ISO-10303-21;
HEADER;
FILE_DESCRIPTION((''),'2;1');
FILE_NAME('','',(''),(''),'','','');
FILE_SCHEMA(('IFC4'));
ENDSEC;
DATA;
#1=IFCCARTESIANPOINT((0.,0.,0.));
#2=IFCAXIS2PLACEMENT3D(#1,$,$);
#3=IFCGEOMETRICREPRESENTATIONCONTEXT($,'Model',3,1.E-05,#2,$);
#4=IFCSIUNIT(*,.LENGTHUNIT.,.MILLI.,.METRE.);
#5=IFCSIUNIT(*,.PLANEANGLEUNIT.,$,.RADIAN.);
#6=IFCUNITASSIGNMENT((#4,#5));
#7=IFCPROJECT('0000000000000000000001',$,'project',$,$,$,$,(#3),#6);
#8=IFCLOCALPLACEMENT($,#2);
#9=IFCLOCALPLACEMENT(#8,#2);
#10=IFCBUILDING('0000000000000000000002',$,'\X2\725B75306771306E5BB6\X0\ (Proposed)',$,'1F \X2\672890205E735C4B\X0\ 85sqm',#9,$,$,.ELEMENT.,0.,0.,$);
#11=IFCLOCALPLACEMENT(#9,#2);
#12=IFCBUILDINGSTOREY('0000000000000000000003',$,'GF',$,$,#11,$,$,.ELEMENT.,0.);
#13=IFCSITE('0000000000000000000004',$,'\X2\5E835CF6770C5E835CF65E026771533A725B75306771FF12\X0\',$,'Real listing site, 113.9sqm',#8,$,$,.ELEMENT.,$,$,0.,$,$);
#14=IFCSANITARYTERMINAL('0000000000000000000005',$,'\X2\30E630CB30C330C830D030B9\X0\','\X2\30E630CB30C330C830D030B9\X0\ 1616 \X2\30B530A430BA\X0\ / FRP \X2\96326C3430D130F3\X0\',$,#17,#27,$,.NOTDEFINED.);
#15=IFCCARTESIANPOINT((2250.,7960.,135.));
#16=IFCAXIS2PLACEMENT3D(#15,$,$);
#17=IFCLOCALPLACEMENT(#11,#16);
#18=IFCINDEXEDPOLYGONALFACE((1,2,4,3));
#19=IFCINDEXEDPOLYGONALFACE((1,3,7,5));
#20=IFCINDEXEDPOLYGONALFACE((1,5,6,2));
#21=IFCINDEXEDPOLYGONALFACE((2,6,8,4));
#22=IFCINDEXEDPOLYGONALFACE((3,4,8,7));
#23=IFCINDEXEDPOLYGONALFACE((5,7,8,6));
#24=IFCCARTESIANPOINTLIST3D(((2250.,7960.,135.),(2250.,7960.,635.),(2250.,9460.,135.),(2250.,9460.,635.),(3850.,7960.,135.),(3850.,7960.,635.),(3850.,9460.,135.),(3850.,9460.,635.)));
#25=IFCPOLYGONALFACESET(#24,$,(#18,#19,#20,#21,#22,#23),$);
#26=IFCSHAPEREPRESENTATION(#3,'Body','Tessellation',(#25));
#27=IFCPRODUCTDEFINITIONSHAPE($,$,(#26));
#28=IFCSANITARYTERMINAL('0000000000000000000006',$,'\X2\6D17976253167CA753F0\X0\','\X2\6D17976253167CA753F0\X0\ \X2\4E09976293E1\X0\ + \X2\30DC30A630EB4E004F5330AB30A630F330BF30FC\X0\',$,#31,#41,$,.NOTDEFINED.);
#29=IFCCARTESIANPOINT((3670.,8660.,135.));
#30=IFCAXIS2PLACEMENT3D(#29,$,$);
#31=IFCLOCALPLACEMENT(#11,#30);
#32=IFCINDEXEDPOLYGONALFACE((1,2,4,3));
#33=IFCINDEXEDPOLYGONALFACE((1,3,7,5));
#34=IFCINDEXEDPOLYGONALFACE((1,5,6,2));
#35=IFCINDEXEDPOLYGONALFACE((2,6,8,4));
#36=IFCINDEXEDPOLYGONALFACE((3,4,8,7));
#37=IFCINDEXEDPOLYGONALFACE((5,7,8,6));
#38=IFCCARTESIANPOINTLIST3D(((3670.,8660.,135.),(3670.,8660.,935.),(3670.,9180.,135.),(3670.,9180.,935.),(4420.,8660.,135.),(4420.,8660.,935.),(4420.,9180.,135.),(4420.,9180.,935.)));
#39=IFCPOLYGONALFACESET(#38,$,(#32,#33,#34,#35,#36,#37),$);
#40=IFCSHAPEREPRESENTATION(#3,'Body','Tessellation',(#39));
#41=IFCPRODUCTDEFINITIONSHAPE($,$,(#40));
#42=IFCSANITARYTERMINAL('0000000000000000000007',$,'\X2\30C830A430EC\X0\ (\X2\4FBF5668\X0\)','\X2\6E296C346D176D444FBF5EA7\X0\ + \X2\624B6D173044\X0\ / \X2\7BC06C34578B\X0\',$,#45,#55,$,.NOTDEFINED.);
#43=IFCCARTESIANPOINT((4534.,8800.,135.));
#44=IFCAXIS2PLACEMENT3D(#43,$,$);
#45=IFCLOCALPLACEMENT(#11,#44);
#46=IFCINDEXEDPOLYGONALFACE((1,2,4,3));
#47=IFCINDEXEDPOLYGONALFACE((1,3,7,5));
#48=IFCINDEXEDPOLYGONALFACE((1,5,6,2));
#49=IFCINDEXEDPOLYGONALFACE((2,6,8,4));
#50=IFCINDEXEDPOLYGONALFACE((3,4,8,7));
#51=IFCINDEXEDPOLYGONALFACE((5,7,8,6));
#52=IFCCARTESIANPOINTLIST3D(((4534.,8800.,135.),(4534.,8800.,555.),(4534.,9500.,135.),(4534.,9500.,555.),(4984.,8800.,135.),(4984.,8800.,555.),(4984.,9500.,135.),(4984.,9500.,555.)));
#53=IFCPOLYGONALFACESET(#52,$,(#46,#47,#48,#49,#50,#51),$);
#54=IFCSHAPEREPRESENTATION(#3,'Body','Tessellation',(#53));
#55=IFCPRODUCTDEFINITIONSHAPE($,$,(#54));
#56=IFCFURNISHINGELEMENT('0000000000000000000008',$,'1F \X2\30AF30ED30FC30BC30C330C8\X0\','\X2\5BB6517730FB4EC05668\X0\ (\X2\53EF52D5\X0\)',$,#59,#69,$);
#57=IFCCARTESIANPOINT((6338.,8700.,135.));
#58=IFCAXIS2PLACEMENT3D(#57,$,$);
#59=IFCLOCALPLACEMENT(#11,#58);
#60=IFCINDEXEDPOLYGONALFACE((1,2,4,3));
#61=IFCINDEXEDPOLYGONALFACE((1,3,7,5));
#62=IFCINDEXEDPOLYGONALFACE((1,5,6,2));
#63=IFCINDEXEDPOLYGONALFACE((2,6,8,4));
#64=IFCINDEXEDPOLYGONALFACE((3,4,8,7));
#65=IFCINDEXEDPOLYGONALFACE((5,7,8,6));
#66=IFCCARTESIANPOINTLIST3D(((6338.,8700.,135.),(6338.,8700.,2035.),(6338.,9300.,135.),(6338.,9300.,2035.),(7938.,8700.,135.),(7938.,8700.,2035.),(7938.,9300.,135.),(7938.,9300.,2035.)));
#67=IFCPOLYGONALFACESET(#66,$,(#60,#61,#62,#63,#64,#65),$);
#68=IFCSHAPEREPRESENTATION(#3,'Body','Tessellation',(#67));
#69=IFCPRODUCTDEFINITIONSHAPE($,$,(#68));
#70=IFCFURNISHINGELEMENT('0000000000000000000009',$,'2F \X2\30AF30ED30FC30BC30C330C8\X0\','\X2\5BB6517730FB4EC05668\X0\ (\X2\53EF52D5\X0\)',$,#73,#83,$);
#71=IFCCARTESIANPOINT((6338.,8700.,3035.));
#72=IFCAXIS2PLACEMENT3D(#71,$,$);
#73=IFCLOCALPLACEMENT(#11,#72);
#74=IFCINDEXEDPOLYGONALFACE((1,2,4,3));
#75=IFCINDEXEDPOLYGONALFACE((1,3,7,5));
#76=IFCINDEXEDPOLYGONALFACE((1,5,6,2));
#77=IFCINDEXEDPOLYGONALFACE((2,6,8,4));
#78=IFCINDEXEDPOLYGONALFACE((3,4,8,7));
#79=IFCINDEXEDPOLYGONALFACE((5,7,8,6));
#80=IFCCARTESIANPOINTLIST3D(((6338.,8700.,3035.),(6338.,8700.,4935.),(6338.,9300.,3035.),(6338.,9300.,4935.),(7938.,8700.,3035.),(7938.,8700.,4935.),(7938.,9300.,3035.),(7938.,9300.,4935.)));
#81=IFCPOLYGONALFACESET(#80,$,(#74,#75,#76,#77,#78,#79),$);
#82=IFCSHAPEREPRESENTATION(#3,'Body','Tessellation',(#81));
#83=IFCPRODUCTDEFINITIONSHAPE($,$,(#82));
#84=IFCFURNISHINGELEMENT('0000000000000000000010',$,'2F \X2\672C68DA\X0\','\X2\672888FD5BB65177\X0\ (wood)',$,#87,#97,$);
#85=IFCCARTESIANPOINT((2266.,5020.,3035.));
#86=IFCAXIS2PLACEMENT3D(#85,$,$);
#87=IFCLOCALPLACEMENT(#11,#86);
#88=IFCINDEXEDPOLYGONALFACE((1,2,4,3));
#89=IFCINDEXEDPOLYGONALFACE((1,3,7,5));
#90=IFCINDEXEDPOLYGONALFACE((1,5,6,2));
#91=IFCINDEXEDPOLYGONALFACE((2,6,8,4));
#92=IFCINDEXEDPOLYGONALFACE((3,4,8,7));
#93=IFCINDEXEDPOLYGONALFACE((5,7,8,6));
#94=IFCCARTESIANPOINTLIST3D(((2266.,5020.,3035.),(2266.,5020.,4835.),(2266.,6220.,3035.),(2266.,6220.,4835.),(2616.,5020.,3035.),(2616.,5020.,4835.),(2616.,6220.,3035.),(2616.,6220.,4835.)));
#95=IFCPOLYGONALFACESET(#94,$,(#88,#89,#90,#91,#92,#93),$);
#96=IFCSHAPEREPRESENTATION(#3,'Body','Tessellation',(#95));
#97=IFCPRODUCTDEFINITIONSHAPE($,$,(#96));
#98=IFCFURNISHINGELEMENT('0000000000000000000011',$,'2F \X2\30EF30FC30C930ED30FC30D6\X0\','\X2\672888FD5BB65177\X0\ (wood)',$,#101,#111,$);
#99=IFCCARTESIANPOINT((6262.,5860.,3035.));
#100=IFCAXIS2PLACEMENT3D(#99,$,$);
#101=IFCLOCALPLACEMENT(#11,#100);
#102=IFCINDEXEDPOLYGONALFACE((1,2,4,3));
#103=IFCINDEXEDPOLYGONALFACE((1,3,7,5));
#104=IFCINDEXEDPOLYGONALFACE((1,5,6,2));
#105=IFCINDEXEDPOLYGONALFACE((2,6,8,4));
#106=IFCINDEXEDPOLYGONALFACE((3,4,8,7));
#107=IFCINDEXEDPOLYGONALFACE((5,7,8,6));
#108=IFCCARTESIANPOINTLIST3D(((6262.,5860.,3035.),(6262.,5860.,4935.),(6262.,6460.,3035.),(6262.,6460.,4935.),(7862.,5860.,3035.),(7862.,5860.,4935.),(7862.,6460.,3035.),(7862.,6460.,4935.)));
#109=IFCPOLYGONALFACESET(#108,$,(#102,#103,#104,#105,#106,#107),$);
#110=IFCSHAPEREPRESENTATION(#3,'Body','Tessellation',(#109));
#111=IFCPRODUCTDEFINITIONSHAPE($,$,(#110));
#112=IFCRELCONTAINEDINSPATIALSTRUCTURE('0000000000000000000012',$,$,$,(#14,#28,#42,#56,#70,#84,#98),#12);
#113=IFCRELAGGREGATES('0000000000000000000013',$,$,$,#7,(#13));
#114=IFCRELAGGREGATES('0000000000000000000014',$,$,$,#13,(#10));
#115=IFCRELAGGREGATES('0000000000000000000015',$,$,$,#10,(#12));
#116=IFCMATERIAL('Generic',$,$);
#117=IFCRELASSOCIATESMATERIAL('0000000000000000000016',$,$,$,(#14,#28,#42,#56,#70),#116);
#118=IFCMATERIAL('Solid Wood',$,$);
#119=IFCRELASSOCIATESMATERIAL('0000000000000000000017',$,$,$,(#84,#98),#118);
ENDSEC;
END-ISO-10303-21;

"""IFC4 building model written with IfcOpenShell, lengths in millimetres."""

from ifc_helpers import new_model, si_unit, frame, frame_2d, origin, place, context, project, spatial, rectangle, extrude, material, element, save


model = new_model("IFC4")

# Units and contexts
model_context = context("Model", 3, precision=1e-05, world=origin())
ifc_project = project(units=[si_unit("LENGTHUNIT", "METRE", prefix="MILLI"), si_unit("PLANEANGLEUNIT", "RADIAN")], contexts=[model_context])

# Site, building, storey
site_placement = place(None, origin())
site = spatial("IfcSite", under=ifc_project, at=site_placement, Name="広島県広島市東区牛田東２", ObjectType="Real listing site, 113.9sqm", CompositionType="ELEMENT", RefElevation=0.0)
building_placement = place(site_placement, origin())
building = spatial("IfcBuilding", under=site, at=building_placement, Name="牛田東の家 (Proposed)", ObjectType="1F 木造平屋 85sqm", CompositionType="ELEMENT", ElevationOfRefHeight=0.0, ElevationOfTerrain=0.0)
storey_placement = place(building_placement, origin())
storey = spatial("IfcBuildingStorey", under=building, at=storey_placement, Name="GF", CompositionType="ELEMENT", Elevation=0.0)

# Shared definitions
ifc_material_1 = material(Name="Solid Wood")

# Shared definitions
ifc_material_2 = material(Name="Generic")

# Sanitary terminals
sanitary_terminal_1_placement = place(storey_placement, frame((2250.0, 7960.0, 135.0)))
element("IfcSanitaryTerminal", 1, at=sanitary_terminal_1_placement, inside=storey, material=ifc_material_2, Name="ユニットバス", Description="ユニットバス 1616 サイズ / FRP 防水パン", PredefinedType="NOTDEFINED", context=model_context, shape_type="SweptSolid", body=[
    extrude(rectangle(XDim=1600.0, YDim=1500.0, at=frame_2d((800.0, 750.0))), frame((2250.0, 7960.0, 135.0)), (0.0, 0.0, 1.0), 500.0),
])
sanitary_terminal_2_placement = place(storey_placement, frame((3670.0, 8660.0, 135.0)))
element("IfcSanitaryTerminal", 2, at=sanitary_terminal_2_placement, inside=storey, material=ifc_material_2, Name="洗面化粧台", Description="洗面化粧台 三面鏡 + ボウル一体カウンター", PredefinedType="NOTDEFINED", context=model_context, shape_type="SweptSolid", body=[
    extrude(rectangle(XDim=750.0, YDim=520.0, at=frame_2d((375.0, 260.0))), frame((3670.0, 8660.0, 135.0)), (0.0, 0.0, 1.0), 800.0),
])
sanitary_terminal_3_placement = place(storey_placement, frame((4534.0, 8800.0, 135.0)))
element("IfcSanitaryTerminal", 3, at=sanitary_terminal_3_placement, inside=storey, material=ifc_material_2, Name="トイレ (便器)", Description="温水洗浄便座 + 手洗い / 節水型", PredefinedType="NOTDEFINED", context=model_context, shape_type="SweptSolid", body=[
    extrude(rectangle(XDim=450.0, YDim=700.0, at=frame_2d((225.0, 350.0))), frame((4534.0, 8800.0, 135.0)), (0.0, 0.0, 1.0), 420.0),
])

# Furnishing elements
furnishing_1_placement = place(storey_placement, frame((6338.0, 8700.0, 135.0)))
element("IfcFurnishingElement", 4, at=furnishing_1_placement, inside=storey, material=ifc_material_2, Name="1F クローゼット", Description="家具・什器 (可動)", context=model_context, shape_type="SweptSolid", body=[
    extrude(rectangle(XDim=1600.0, YDim=600.0, at=frame_2d((800.0, 300.0))), frame((6338.0, 8700.0, 135.0)), (0.0, 0.0, 1.0), 1900.0),
])
furnishing_2_placement = place(storey_placement, frame((6338.0, 8700.0, 3035.0)))
element("IfcFurnishingElement", 5, at=furnishing_2_placement, inside=storey, material=ifc_material_2, Name="2F クローゼット", Description="家具・什器 (可動)", context=model_context, shape_type="SweptSolid", body=[
    extrude(rectangle(XDim=1600.0, YDim=600.0, at=frame_2d((800.0, 300.0))), frame((6338.0, 8700.0, 3035.0)), (0.0, 0.0, 1.0), 1900.0),
])
furnishing_3_placement = place(storey_placement, frame((2266.0, 5020.0, 3035.0)))
element("IfcFurnishingElement", 6, at=furnishing_3_placement, inside=storey, material=ifc_material_1, Name="2F 本棚", Description="木製家具 (wood)", context=model_context, shape_type="SweptSolid", body=[
    extrude(rectangle(XDim=350.0, YDim=1200.0, at=frame_2d((175.0, 600.0))), frame((2266.0, 5020.0, 3035.0)), (0.0, 0.0, 1.0), 1800.0),
])
furnishing_4_placement = place(storey_placement, frame((6262.0, 5860.0, 3035.0)))
element("IfcFurnishingElement", 7, at=furnishing_4_placement, inside=storey, material=ifc_material_1, Name="2F ワードローブ", Description="木製家具 (wood)", context=model_context, shape_type="SweptSolid", body=[
    extrude(rectangle(XDim=1600.0, YDim=600.0, at=frame_2d((800.0, 300.0))), frame((6262.0, 5860.0, 3035.0)), (0.0, 0.0, 1.0), 1900.0),
])

save(model, "model.ifc")
